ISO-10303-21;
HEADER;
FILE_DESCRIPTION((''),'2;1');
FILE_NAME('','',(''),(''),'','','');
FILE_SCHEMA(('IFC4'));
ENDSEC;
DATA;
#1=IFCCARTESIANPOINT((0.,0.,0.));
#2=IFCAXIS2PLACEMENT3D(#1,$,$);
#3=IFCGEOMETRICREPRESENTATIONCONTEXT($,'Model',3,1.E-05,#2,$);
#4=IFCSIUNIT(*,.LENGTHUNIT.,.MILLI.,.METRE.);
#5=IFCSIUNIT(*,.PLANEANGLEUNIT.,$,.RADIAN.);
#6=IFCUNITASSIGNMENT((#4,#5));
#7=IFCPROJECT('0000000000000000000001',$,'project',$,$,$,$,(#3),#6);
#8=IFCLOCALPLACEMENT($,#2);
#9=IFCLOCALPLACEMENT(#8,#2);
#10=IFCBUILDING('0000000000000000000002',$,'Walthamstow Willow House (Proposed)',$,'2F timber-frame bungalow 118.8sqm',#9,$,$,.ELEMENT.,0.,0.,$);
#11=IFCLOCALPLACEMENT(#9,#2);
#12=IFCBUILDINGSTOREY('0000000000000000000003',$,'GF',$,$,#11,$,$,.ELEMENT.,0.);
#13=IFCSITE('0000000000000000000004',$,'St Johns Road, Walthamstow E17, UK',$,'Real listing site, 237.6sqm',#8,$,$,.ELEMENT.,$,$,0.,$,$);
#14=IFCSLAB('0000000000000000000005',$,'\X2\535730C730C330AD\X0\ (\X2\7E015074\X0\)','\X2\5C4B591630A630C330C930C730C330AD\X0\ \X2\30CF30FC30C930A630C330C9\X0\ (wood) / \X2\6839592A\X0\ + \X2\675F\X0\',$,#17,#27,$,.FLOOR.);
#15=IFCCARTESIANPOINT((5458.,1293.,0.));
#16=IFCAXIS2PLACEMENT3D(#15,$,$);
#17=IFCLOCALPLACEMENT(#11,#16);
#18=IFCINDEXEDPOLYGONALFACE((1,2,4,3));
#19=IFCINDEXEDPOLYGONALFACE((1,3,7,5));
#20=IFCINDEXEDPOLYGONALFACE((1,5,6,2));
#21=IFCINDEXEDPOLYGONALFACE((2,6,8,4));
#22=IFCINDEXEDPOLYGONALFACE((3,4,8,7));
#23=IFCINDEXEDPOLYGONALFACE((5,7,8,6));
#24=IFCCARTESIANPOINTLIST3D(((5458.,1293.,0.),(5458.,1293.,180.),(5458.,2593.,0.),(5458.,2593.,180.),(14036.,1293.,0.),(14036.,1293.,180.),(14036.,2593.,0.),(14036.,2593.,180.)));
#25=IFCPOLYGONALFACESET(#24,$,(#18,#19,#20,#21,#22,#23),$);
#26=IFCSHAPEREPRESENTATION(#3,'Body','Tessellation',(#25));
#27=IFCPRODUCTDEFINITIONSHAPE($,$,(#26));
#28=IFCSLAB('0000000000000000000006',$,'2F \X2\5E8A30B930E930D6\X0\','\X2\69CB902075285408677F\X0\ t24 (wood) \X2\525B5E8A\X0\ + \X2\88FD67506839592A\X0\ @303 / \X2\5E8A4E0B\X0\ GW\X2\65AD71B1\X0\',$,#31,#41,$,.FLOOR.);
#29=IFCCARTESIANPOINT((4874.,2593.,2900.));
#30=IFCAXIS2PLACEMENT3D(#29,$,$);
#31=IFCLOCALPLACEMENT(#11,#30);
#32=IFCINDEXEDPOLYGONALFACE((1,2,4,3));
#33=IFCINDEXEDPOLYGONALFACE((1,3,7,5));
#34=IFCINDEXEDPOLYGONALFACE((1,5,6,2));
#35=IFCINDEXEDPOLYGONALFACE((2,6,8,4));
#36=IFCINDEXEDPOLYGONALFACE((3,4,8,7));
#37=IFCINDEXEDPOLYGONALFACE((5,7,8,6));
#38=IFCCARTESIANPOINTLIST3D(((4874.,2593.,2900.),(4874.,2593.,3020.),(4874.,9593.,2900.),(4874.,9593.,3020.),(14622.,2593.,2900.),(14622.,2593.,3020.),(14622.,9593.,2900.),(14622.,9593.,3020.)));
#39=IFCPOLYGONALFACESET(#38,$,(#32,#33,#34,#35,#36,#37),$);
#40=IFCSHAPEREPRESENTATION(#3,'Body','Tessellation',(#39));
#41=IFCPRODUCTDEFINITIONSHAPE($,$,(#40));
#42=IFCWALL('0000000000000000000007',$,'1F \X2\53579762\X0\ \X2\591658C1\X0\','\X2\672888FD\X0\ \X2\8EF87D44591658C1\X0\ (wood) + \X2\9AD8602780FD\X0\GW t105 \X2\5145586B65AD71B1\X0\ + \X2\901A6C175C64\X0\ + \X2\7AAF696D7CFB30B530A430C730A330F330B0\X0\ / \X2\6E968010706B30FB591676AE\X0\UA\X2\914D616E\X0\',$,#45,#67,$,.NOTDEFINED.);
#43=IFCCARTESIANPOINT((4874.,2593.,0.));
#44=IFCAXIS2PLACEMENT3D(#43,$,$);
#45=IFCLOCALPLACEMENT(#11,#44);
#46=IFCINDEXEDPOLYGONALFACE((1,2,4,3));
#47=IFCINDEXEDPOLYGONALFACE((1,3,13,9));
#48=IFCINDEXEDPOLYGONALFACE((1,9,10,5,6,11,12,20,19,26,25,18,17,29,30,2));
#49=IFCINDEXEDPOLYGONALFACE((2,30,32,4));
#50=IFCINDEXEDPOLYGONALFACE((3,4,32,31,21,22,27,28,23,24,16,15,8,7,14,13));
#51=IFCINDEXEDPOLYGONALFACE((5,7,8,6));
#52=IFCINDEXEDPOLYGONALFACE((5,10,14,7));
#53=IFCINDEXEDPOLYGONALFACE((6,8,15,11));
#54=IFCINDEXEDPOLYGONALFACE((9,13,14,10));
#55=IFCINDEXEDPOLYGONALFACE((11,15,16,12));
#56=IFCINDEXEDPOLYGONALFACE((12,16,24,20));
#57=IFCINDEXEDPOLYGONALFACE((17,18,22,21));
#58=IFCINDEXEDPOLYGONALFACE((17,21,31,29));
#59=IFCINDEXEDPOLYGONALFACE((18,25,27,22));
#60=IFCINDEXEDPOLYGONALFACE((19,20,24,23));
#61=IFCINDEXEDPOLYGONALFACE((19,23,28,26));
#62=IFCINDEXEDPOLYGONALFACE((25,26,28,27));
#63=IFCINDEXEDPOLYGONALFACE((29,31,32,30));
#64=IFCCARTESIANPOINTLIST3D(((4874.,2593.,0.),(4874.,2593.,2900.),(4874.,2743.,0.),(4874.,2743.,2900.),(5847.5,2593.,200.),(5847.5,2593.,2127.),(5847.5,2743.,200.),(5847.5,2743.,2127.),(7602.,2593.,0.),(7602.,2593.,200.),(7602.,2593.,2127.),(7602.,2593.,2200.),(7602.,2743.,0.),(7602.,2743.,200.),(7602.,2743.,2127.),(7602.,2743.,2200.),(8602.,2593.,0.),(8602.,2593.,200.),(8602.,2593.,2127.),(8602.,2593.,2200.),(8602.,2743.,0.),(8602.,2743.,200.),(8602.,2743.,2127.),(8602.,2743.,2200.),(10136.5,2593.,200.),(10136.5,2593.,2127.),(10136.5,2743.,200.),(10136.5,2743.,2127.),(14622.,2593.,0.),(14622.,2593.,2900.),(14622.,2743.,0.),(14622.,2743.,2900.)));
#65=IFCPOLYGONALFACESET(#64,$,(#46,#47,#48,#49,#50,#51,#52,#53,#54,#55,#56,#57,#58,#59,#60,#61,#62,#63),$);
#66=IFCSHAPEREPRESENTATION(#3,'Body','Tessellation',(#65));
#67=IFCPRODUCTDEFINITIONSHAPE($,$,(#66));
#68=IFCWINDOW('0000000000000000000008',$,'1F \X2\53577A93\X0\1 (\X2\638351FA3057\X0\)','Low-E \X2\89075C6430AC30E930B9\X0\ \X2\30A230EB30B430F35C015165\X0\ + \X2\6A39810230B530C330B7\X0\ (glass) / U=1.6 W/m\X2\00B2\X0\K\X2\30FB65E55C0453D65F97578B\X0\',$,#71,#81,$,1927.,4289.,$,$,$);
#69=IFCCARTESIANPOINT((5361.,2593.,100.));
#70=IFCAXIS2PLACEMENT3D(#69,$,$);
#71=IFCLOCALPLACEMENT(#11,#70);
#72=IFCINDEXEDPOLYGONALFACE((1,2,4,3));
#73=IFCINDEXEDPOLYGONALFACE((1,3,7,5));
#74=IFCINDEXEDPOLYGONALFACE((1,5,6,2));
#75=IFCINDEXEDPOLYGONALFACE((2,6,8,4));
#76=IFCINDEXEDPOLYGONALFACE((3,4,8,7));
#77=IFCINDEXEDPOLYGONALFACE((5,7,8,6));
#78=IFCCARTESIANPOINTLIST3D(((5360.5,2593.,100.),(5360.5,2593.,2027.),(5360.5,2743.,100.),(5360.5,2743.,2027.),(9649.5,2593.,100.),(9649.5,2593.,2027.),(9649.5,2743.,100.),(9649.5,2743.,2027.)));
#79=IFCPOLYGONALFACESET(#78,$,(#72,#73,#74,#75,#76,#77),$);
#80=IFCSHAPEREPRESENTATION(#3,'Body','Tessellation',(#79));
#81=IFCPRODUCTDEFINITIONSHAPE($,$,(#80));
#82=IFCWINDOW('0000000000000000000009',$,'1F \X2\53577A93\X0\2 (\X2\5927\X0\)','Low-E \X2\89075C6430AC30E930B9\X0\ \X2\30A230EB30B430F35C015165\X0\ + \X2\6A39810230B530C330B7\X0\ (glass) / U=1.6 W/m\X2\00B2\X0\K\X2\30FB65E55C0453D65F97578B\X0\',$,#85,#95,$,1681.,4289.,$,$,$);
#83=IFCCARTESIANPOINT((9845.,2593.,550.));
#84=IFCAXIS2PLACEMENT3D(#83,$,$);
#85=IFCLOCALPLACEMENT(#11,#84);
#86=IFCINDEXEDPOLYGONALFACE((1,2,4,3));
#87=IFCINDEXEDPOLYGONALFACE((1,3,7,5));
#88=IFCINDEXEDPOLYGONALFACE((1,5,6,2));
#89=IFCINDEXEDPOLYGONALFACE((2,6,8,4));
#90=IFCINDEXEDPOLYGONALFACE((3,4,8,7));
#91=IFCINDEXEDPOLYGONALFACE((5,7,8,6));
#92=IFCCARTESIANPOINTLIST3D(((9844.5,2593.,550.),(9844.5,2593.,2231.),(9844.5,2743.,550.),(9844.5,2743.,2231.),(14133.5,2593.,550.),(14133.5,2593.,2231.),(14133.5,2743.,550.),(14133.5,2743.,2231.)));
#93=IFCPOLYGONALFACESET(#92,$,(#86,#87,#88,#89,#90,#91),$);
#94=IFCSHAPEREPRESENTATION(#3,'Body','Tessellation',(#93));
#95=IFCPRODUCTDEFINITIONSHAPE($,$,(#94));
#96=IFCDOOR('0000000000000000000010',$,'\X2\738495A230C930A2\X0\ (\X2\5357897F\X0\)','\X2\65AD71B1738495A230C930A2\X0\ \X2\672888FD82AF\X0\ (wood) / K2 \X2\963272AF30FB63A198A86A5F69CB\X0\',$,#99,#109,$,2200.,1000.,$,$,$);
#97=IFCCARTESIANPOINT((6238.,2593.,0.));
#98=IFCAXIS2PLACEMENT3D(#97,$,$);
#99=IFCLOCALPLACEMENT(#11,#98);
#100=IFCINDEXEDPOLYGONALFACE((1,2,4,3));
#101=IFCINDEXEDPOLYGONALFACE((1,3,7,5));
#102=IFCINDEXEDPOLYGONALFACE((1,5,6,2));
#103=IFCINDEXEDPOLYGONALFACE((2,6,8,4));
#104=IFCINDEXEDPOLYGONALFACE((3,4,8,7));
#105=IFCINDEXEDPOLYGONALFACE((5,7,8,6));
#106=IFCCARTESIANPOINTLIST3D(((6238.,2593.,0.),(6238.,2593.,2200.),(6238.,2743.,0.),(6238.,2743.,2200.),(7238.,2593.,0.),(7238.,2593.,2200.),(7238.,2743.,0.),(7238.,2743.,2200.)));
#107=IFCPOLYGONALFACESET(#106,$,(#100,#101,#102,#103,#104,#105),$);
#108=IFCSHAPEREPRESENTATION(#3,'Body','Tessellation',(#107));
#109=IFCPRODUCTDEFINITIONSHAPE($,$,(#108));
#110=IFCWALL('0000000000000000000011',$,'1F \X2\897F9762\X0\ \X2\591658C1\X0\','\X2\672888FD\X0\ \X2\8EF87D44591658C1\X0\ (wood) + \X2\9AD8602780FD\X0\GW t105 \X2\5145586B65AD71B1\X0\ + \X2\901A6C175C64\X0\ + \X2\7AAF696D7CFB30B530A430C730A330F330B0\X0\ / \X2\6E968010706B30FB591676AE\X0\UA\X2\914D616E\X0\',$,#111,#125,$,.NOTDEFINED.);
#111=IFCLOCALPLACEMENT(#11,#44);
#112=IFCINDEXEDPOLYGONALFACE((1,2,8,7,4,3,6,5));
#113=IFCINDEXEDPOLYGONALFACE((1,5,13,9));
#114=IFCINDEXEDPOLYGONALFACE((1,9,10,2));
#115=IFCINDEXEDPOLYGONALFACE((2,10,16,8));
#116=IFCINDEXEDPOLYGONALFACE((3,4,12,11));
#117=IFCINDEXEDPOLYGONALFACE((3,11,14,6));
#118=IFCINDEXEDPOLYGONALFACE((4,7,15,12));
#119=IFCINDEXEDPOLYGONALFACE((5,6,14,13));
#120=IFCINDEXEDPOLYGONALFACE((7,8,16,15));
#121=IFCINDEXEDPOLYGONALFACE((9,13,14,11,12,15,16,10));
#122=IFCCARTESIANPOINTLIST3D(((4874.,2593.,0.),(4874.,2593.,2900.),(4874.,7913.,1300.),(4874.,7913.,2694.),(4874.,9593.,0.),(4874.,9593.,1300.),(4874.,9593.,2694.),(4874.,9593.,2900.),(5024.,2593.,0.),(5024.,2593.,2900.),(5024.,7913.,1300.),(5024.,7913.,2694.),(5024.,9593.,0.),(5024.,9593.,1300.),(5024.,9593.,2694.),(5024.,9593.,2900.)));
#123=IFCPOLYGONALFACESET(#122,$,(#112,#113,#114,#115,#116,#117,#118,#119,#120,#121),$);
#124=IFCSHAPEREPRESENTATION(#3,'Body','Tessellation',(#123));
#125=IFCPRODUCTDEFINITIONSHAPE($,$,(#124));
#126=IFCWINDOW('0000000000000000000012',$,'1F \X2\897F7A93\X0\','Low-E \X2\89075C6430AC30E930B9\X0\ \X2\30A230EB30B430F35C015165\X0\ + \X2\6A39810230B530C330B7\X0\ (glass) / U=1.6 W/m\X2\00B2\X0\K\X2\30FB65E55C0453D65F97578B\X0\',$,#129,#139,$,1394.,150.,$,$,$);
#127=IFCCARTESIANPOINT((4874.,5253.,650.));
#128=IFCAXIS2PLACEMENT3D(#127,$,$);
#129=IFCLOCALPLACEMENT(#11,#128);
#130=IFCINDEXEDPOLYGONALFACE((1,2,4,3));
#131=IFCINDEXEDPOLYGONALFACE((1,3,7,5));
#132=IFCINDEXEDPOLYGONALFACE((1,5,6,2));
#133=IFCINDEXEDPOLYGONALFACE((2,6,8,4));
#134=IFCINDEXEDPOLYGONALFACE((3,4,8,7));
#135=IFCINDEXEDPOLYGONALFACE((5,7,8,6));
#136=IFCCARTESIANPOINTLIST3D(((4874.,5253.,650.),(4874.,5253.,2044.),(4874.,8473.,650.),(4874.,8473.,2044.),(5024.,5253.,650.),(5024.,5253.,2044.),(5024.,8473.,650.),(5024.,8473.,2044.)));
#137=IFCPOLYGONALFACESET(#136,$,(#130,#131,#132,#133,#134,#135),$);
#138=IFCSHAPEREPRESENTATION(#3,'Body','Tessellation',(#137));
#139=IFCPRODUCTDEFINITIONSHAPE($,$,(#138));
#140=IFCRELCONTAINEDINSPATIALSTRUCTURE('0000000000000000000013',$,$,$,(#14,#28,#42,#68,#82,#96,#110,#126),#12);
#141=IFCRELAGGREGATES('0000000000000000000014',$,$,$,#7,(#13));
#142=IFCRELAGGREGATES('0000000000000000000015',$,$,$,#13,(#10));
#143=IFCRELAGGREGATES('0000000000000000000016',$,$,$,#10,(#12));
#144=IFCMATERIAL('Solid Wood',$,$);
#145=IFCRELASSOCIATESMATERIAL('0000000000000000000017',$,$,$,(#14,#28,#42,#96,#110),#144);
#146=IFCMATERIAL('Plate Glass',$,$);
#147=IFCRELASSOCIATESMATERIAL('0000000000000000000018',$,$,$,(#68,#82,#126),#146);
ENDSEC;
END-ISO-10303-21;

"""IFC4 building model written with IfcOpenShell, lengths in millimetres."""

from ifc_helpers import new_model, si_unit, frame, frame_2d, origin, place, context, project, spatial, rectangle, extrude, material, element, fill, save


model = new_model("IFC4")

# Units and contexts
model_context = context("Model", 3, precision=1e-05, world=origin())
ifc_project = project(units=[si_unit("LENGTHUNIT", "METRE", prefix="MILLI"), si_unit("PLANEANGLEUNIT", "RADIAN")], contexts=[model_context])

# Site, building, storey
site_placement = place(None, origin())
site = spatial("IfcSite", under=ifc_project, at=site_placement, Name="St Johns Road, Walthamstow E17, UK", ObjectType="Real listing site, 237.6sqm", CompositionType="ELEMENT", RefElevation=0.0)
building_placement = place(site_placement, origin())
building = spatial("IfcBuilding", under=site, at=building_placement, Name="Walthamstow Willow House (Proposed)", ObjectType="2F timber-frame bungalow 118.8sqm", CompositionType="ELEMENT", ElevationOfRefHeight=0.0, ElevationOfTerrain=0.0)
storey_placement = place(building_placement, origin())
storey = spatial("IfcBuildingStorey", under=building, at=storey_placement, Name="GF", CompositionType="ELEMENT", Elevation=0.0)

# Slabs
ifc_material_1 = material(Name="Solid Wood")
slab_1_placement = place(storey_placement, frame((5458.0, 1293.0, 0.0)))
element("IfcSlab", 1, at=slab_1_placement, inside=storey, material=ifc_material_1, Name="南デッキ (縁側)", Description="屋外ウッドデッキ ハードウッド (wood) / 根太 + 束", PredefinedType="FLOOR", context=model_context, shape_type="SweptSolid", body=[
    extrude(rectangle(XDim=8578.0, YDim=1300.0, at=frame_2d((4289.0, 650.0))), frame((5458.0, 1293.0, 0.0)), (0.0, 0.0, 1.0), 180.0),
])
slab_2_placement = place(storey_placement, frame((4874.0, 2593.0, 2900.0)))
element("IfcSlab", 2, at=slab_2_placement, inside=storey, material=ifc_material_1, Name="2F 床スラブ", Description="構造用合板 t24 (wood) 剛床 + 製材根太 @303 / 床下 GW断熱", PredefinedType="FLOOR", context=model_context, shape_type="SweptSolid", body=[
    extrude(rectangle(XDim=9748.0, YDim=7000.0, at=frame_2d((4874.0, 3500.0))), frame((4874.0, 2593.0, 2900.0)), (0.0, 0.0, 1.0), 120.0),
])

# Wall, openings, windows, door
wall_1_placement = place(storey_placement, frame((4874.0, 2593.0, 0.0)))
wall_1 = element("IfcWall", 3, at=wall_1_placement, inside=storey, material=ifc_material_1, Name="1F 南面 外壁", Description="木製 軸組外壁 (wood) + 高性能GW t105 充填断熱 + 通気層 + 窯業系サイディング / 準耐火・外皮UA配慮", PredefinedType="NOTDEFINED", context=model_context, shape_type="SweptSolid", body=[
    extrude(rectangle(XDim=9748.0, YDim=150.0, at=frame_2d((4874.0, 75.0))), frame((4874.0, 2593.0, 0.0)), (0.0, 0.0, 1.0), 2900.0),
])
opening_1_placement = place(storey_placement, frame((5361.0, 2593.0, 100.0)))
opening_1 = element("IfcOpeningElement", 4, at=opening_1_placement, cuts=wall_1, PredefinedType="NOTDEFINED", context=model_context, shape_type="SweptSolid", body=[
    extrude(rectangle(XDim=4289.0, YDim=150.0, at=frame_2d((2144.0, 75.0))), frame((5361.0, 2593.0, 100.0)), (0.0, 0.0, 1.0), 1927.0),
])
opening_2_placement = place(storey_placement, frame((9845.0, 2593.0, 550.0)))
opening_2 = element("IfcOpeningElement", 5, at=opening_2_placement, cuts=wall_1, PredefinedType="NOTDEFINED", context=model_context, shape_type="SweptSolid", body=[
    extrude(rectangle(XDim=4289.0, YDim=150.0, at=frame_2d((2144.0, 75.0))), frame((9845.0, 2593.0, 550.0)), (0.0, 0.0, 1.0), 1681.0),
])
opening_3_placement = place(storey_placement, frame((6238.0, 2593.0, 0.0)))
opening_3 = element("IfcOpeningElement", 6, at=opening_3_placement, cuts=wall_1, PredefinedType="NOTDEFINED", context=model_context, shape_type="SweptSolid", body=[
    extrude(rectangle(XDim=1000.0, YDim=150.0, at=frame_2d((500.0, 75.0))), frame((6238.0, 2593.0, 0.0)), (0.0, 0.0, 1.0), 2200.0),
])
ifc_material_2 = material(Name="Plate Glass")
window_1_placement = place(storey_placement, frame((5361.0, 2593.0, 100.0)))
window_1 = element("IfcWindow", 7, at=window_1_placement, inside=storey, material=ifc_material_2, Name="1F 南窓1 (掃出し)", Description="Low-E 複層ガラス アルゴン封入 + 樹脂サッシ (glass) / U=1.6 W/m²K・日射取得型", OverallHeight=1927.0, OverallWidth=4289.0, context=model_context, shape_type="SweptSolid", body=[
    extrude(rectangle(XDim=4289.0, YDim=150.0, at=frame_2d((2144.0, 75.0))), frame((5361.0, 2593.0, 100.0)), (0.0, 0.0, 1.0), 1927.0),
])
fill(opening_1, window_1)
window_2_placement = place(storey_placement, frame((9845.0, 2593.0, 550.0)))
window_2 = element("IfcWindow", 8, at=window_2_placement, inside=storey, material=ifc_material_2, Name="1F 南窓2 (大)", Description="Low-E 複層ガラス アルゴン封入 + 樹脂サッシ (glass) / U=1.6 W/m²K・日射取得型", OverallHeight=1681.0, OverallWidth=4289.0, context=model_context, shape_type="SweptSolid", body=[
    extrude(rectangle(XDim=4289.0, YDim=150.0, at=frame_2d((2144.0, 75.0))), frame((9845.0, 2593.0, 550.0)), (0.0, 0.0, 1.0), 1681.0),
])
fill(opening_2, window_2)
door_placement = place(storey_placement, frame((6238.0, 2593.0, 0.0)))
door = element("IfcDoor", 9, at=door_placement, inside=storey, material=ifc_material_1, Name="玄関ドア (南西)", Description="断熱玄関ドア 木製芯 (wood) / K2 防犯・採風機構", OverallHeight=2200.0, OverallWidth=1000.0, context=model_context, shape_type="SweptSolid", body=[
    extrude(rectangle(XDim=1000.0, YDim=150.0, at=frame_2d((500.0, 75.0))), frame((6238.0, 2593.0, 0.0)), (0.0, 0.0, 1.0), 2200.0),
])
fill(opening_3, door)

# Wall, opening, window
wall_2_placement = place(storey_placement, frame((4874.0, 2593.0, 0.0)))
wall_2 = element("IfcWall", 10, at=wall_2_placement, inside=storey, material=ifc_material_1, Name="1F 西面 外壁", Description="木製 軸組外壁 (wood) + 高性能GW t105 充填断熱 + 通気層 + 窯業系サイディング / 準耐火・外皮UA配慮", PredefinedType="NOTDEFINED", context=model_context, shape_type="SweptSolid", body=[
    extrude(rectangle(XDim=150.0, YDim=7000.0, at=frame_2d((75.0, 3500.0))), frame((4874.0, 2593.0, 0.0)), (0.0, 0.0, 1.0), 2900.0),
])
opening_4_placement = place(storey_placement, frame((4874.0, 5253.0, 650.0)))
opening_4 = element("IfcOpeningElement", 11, at=opening_4_placement, cuts=wall_2, PredefinedType="NOTDEFINED", context=model_context, shape_type="SweptSolid", body=[
    extrude(rectangle(XDim=150.0, YDim=3220.0, at=frame_2d((75.0, 1610.0))), frame((4874.0, 5253.0, 650.0)), (0.0, 0.0, 1.0), 1394.0),
])
window_3_placement = place(storey_placement, frame((4874.0, 5253.0, 650.0)))
window_3 = element("IfcWindow", 12, at=window_3_placement, inside=storey, material=ifc_material_2, Name="1F 西窓", Description="Low-E 複層ガラス アルゴン封入 + 樹脂サッシ (glass) / U=1.6 W/m²K・日射取得型", OverallHeight=1394.0, OverallWidth=150.0, context=model_context, shape_type="SweptSolid", body=[
    extrude(rectangle(XDim=150.0, YDim=3220.0, at=frame_2d((75.0, 1610.0))), frame((4874.0, 5253.0, 650.0)), (0.0, 0.0, 1.0), 1394.0),
])
fill(opening_4, window_3)

save(model, "model.ifc")
